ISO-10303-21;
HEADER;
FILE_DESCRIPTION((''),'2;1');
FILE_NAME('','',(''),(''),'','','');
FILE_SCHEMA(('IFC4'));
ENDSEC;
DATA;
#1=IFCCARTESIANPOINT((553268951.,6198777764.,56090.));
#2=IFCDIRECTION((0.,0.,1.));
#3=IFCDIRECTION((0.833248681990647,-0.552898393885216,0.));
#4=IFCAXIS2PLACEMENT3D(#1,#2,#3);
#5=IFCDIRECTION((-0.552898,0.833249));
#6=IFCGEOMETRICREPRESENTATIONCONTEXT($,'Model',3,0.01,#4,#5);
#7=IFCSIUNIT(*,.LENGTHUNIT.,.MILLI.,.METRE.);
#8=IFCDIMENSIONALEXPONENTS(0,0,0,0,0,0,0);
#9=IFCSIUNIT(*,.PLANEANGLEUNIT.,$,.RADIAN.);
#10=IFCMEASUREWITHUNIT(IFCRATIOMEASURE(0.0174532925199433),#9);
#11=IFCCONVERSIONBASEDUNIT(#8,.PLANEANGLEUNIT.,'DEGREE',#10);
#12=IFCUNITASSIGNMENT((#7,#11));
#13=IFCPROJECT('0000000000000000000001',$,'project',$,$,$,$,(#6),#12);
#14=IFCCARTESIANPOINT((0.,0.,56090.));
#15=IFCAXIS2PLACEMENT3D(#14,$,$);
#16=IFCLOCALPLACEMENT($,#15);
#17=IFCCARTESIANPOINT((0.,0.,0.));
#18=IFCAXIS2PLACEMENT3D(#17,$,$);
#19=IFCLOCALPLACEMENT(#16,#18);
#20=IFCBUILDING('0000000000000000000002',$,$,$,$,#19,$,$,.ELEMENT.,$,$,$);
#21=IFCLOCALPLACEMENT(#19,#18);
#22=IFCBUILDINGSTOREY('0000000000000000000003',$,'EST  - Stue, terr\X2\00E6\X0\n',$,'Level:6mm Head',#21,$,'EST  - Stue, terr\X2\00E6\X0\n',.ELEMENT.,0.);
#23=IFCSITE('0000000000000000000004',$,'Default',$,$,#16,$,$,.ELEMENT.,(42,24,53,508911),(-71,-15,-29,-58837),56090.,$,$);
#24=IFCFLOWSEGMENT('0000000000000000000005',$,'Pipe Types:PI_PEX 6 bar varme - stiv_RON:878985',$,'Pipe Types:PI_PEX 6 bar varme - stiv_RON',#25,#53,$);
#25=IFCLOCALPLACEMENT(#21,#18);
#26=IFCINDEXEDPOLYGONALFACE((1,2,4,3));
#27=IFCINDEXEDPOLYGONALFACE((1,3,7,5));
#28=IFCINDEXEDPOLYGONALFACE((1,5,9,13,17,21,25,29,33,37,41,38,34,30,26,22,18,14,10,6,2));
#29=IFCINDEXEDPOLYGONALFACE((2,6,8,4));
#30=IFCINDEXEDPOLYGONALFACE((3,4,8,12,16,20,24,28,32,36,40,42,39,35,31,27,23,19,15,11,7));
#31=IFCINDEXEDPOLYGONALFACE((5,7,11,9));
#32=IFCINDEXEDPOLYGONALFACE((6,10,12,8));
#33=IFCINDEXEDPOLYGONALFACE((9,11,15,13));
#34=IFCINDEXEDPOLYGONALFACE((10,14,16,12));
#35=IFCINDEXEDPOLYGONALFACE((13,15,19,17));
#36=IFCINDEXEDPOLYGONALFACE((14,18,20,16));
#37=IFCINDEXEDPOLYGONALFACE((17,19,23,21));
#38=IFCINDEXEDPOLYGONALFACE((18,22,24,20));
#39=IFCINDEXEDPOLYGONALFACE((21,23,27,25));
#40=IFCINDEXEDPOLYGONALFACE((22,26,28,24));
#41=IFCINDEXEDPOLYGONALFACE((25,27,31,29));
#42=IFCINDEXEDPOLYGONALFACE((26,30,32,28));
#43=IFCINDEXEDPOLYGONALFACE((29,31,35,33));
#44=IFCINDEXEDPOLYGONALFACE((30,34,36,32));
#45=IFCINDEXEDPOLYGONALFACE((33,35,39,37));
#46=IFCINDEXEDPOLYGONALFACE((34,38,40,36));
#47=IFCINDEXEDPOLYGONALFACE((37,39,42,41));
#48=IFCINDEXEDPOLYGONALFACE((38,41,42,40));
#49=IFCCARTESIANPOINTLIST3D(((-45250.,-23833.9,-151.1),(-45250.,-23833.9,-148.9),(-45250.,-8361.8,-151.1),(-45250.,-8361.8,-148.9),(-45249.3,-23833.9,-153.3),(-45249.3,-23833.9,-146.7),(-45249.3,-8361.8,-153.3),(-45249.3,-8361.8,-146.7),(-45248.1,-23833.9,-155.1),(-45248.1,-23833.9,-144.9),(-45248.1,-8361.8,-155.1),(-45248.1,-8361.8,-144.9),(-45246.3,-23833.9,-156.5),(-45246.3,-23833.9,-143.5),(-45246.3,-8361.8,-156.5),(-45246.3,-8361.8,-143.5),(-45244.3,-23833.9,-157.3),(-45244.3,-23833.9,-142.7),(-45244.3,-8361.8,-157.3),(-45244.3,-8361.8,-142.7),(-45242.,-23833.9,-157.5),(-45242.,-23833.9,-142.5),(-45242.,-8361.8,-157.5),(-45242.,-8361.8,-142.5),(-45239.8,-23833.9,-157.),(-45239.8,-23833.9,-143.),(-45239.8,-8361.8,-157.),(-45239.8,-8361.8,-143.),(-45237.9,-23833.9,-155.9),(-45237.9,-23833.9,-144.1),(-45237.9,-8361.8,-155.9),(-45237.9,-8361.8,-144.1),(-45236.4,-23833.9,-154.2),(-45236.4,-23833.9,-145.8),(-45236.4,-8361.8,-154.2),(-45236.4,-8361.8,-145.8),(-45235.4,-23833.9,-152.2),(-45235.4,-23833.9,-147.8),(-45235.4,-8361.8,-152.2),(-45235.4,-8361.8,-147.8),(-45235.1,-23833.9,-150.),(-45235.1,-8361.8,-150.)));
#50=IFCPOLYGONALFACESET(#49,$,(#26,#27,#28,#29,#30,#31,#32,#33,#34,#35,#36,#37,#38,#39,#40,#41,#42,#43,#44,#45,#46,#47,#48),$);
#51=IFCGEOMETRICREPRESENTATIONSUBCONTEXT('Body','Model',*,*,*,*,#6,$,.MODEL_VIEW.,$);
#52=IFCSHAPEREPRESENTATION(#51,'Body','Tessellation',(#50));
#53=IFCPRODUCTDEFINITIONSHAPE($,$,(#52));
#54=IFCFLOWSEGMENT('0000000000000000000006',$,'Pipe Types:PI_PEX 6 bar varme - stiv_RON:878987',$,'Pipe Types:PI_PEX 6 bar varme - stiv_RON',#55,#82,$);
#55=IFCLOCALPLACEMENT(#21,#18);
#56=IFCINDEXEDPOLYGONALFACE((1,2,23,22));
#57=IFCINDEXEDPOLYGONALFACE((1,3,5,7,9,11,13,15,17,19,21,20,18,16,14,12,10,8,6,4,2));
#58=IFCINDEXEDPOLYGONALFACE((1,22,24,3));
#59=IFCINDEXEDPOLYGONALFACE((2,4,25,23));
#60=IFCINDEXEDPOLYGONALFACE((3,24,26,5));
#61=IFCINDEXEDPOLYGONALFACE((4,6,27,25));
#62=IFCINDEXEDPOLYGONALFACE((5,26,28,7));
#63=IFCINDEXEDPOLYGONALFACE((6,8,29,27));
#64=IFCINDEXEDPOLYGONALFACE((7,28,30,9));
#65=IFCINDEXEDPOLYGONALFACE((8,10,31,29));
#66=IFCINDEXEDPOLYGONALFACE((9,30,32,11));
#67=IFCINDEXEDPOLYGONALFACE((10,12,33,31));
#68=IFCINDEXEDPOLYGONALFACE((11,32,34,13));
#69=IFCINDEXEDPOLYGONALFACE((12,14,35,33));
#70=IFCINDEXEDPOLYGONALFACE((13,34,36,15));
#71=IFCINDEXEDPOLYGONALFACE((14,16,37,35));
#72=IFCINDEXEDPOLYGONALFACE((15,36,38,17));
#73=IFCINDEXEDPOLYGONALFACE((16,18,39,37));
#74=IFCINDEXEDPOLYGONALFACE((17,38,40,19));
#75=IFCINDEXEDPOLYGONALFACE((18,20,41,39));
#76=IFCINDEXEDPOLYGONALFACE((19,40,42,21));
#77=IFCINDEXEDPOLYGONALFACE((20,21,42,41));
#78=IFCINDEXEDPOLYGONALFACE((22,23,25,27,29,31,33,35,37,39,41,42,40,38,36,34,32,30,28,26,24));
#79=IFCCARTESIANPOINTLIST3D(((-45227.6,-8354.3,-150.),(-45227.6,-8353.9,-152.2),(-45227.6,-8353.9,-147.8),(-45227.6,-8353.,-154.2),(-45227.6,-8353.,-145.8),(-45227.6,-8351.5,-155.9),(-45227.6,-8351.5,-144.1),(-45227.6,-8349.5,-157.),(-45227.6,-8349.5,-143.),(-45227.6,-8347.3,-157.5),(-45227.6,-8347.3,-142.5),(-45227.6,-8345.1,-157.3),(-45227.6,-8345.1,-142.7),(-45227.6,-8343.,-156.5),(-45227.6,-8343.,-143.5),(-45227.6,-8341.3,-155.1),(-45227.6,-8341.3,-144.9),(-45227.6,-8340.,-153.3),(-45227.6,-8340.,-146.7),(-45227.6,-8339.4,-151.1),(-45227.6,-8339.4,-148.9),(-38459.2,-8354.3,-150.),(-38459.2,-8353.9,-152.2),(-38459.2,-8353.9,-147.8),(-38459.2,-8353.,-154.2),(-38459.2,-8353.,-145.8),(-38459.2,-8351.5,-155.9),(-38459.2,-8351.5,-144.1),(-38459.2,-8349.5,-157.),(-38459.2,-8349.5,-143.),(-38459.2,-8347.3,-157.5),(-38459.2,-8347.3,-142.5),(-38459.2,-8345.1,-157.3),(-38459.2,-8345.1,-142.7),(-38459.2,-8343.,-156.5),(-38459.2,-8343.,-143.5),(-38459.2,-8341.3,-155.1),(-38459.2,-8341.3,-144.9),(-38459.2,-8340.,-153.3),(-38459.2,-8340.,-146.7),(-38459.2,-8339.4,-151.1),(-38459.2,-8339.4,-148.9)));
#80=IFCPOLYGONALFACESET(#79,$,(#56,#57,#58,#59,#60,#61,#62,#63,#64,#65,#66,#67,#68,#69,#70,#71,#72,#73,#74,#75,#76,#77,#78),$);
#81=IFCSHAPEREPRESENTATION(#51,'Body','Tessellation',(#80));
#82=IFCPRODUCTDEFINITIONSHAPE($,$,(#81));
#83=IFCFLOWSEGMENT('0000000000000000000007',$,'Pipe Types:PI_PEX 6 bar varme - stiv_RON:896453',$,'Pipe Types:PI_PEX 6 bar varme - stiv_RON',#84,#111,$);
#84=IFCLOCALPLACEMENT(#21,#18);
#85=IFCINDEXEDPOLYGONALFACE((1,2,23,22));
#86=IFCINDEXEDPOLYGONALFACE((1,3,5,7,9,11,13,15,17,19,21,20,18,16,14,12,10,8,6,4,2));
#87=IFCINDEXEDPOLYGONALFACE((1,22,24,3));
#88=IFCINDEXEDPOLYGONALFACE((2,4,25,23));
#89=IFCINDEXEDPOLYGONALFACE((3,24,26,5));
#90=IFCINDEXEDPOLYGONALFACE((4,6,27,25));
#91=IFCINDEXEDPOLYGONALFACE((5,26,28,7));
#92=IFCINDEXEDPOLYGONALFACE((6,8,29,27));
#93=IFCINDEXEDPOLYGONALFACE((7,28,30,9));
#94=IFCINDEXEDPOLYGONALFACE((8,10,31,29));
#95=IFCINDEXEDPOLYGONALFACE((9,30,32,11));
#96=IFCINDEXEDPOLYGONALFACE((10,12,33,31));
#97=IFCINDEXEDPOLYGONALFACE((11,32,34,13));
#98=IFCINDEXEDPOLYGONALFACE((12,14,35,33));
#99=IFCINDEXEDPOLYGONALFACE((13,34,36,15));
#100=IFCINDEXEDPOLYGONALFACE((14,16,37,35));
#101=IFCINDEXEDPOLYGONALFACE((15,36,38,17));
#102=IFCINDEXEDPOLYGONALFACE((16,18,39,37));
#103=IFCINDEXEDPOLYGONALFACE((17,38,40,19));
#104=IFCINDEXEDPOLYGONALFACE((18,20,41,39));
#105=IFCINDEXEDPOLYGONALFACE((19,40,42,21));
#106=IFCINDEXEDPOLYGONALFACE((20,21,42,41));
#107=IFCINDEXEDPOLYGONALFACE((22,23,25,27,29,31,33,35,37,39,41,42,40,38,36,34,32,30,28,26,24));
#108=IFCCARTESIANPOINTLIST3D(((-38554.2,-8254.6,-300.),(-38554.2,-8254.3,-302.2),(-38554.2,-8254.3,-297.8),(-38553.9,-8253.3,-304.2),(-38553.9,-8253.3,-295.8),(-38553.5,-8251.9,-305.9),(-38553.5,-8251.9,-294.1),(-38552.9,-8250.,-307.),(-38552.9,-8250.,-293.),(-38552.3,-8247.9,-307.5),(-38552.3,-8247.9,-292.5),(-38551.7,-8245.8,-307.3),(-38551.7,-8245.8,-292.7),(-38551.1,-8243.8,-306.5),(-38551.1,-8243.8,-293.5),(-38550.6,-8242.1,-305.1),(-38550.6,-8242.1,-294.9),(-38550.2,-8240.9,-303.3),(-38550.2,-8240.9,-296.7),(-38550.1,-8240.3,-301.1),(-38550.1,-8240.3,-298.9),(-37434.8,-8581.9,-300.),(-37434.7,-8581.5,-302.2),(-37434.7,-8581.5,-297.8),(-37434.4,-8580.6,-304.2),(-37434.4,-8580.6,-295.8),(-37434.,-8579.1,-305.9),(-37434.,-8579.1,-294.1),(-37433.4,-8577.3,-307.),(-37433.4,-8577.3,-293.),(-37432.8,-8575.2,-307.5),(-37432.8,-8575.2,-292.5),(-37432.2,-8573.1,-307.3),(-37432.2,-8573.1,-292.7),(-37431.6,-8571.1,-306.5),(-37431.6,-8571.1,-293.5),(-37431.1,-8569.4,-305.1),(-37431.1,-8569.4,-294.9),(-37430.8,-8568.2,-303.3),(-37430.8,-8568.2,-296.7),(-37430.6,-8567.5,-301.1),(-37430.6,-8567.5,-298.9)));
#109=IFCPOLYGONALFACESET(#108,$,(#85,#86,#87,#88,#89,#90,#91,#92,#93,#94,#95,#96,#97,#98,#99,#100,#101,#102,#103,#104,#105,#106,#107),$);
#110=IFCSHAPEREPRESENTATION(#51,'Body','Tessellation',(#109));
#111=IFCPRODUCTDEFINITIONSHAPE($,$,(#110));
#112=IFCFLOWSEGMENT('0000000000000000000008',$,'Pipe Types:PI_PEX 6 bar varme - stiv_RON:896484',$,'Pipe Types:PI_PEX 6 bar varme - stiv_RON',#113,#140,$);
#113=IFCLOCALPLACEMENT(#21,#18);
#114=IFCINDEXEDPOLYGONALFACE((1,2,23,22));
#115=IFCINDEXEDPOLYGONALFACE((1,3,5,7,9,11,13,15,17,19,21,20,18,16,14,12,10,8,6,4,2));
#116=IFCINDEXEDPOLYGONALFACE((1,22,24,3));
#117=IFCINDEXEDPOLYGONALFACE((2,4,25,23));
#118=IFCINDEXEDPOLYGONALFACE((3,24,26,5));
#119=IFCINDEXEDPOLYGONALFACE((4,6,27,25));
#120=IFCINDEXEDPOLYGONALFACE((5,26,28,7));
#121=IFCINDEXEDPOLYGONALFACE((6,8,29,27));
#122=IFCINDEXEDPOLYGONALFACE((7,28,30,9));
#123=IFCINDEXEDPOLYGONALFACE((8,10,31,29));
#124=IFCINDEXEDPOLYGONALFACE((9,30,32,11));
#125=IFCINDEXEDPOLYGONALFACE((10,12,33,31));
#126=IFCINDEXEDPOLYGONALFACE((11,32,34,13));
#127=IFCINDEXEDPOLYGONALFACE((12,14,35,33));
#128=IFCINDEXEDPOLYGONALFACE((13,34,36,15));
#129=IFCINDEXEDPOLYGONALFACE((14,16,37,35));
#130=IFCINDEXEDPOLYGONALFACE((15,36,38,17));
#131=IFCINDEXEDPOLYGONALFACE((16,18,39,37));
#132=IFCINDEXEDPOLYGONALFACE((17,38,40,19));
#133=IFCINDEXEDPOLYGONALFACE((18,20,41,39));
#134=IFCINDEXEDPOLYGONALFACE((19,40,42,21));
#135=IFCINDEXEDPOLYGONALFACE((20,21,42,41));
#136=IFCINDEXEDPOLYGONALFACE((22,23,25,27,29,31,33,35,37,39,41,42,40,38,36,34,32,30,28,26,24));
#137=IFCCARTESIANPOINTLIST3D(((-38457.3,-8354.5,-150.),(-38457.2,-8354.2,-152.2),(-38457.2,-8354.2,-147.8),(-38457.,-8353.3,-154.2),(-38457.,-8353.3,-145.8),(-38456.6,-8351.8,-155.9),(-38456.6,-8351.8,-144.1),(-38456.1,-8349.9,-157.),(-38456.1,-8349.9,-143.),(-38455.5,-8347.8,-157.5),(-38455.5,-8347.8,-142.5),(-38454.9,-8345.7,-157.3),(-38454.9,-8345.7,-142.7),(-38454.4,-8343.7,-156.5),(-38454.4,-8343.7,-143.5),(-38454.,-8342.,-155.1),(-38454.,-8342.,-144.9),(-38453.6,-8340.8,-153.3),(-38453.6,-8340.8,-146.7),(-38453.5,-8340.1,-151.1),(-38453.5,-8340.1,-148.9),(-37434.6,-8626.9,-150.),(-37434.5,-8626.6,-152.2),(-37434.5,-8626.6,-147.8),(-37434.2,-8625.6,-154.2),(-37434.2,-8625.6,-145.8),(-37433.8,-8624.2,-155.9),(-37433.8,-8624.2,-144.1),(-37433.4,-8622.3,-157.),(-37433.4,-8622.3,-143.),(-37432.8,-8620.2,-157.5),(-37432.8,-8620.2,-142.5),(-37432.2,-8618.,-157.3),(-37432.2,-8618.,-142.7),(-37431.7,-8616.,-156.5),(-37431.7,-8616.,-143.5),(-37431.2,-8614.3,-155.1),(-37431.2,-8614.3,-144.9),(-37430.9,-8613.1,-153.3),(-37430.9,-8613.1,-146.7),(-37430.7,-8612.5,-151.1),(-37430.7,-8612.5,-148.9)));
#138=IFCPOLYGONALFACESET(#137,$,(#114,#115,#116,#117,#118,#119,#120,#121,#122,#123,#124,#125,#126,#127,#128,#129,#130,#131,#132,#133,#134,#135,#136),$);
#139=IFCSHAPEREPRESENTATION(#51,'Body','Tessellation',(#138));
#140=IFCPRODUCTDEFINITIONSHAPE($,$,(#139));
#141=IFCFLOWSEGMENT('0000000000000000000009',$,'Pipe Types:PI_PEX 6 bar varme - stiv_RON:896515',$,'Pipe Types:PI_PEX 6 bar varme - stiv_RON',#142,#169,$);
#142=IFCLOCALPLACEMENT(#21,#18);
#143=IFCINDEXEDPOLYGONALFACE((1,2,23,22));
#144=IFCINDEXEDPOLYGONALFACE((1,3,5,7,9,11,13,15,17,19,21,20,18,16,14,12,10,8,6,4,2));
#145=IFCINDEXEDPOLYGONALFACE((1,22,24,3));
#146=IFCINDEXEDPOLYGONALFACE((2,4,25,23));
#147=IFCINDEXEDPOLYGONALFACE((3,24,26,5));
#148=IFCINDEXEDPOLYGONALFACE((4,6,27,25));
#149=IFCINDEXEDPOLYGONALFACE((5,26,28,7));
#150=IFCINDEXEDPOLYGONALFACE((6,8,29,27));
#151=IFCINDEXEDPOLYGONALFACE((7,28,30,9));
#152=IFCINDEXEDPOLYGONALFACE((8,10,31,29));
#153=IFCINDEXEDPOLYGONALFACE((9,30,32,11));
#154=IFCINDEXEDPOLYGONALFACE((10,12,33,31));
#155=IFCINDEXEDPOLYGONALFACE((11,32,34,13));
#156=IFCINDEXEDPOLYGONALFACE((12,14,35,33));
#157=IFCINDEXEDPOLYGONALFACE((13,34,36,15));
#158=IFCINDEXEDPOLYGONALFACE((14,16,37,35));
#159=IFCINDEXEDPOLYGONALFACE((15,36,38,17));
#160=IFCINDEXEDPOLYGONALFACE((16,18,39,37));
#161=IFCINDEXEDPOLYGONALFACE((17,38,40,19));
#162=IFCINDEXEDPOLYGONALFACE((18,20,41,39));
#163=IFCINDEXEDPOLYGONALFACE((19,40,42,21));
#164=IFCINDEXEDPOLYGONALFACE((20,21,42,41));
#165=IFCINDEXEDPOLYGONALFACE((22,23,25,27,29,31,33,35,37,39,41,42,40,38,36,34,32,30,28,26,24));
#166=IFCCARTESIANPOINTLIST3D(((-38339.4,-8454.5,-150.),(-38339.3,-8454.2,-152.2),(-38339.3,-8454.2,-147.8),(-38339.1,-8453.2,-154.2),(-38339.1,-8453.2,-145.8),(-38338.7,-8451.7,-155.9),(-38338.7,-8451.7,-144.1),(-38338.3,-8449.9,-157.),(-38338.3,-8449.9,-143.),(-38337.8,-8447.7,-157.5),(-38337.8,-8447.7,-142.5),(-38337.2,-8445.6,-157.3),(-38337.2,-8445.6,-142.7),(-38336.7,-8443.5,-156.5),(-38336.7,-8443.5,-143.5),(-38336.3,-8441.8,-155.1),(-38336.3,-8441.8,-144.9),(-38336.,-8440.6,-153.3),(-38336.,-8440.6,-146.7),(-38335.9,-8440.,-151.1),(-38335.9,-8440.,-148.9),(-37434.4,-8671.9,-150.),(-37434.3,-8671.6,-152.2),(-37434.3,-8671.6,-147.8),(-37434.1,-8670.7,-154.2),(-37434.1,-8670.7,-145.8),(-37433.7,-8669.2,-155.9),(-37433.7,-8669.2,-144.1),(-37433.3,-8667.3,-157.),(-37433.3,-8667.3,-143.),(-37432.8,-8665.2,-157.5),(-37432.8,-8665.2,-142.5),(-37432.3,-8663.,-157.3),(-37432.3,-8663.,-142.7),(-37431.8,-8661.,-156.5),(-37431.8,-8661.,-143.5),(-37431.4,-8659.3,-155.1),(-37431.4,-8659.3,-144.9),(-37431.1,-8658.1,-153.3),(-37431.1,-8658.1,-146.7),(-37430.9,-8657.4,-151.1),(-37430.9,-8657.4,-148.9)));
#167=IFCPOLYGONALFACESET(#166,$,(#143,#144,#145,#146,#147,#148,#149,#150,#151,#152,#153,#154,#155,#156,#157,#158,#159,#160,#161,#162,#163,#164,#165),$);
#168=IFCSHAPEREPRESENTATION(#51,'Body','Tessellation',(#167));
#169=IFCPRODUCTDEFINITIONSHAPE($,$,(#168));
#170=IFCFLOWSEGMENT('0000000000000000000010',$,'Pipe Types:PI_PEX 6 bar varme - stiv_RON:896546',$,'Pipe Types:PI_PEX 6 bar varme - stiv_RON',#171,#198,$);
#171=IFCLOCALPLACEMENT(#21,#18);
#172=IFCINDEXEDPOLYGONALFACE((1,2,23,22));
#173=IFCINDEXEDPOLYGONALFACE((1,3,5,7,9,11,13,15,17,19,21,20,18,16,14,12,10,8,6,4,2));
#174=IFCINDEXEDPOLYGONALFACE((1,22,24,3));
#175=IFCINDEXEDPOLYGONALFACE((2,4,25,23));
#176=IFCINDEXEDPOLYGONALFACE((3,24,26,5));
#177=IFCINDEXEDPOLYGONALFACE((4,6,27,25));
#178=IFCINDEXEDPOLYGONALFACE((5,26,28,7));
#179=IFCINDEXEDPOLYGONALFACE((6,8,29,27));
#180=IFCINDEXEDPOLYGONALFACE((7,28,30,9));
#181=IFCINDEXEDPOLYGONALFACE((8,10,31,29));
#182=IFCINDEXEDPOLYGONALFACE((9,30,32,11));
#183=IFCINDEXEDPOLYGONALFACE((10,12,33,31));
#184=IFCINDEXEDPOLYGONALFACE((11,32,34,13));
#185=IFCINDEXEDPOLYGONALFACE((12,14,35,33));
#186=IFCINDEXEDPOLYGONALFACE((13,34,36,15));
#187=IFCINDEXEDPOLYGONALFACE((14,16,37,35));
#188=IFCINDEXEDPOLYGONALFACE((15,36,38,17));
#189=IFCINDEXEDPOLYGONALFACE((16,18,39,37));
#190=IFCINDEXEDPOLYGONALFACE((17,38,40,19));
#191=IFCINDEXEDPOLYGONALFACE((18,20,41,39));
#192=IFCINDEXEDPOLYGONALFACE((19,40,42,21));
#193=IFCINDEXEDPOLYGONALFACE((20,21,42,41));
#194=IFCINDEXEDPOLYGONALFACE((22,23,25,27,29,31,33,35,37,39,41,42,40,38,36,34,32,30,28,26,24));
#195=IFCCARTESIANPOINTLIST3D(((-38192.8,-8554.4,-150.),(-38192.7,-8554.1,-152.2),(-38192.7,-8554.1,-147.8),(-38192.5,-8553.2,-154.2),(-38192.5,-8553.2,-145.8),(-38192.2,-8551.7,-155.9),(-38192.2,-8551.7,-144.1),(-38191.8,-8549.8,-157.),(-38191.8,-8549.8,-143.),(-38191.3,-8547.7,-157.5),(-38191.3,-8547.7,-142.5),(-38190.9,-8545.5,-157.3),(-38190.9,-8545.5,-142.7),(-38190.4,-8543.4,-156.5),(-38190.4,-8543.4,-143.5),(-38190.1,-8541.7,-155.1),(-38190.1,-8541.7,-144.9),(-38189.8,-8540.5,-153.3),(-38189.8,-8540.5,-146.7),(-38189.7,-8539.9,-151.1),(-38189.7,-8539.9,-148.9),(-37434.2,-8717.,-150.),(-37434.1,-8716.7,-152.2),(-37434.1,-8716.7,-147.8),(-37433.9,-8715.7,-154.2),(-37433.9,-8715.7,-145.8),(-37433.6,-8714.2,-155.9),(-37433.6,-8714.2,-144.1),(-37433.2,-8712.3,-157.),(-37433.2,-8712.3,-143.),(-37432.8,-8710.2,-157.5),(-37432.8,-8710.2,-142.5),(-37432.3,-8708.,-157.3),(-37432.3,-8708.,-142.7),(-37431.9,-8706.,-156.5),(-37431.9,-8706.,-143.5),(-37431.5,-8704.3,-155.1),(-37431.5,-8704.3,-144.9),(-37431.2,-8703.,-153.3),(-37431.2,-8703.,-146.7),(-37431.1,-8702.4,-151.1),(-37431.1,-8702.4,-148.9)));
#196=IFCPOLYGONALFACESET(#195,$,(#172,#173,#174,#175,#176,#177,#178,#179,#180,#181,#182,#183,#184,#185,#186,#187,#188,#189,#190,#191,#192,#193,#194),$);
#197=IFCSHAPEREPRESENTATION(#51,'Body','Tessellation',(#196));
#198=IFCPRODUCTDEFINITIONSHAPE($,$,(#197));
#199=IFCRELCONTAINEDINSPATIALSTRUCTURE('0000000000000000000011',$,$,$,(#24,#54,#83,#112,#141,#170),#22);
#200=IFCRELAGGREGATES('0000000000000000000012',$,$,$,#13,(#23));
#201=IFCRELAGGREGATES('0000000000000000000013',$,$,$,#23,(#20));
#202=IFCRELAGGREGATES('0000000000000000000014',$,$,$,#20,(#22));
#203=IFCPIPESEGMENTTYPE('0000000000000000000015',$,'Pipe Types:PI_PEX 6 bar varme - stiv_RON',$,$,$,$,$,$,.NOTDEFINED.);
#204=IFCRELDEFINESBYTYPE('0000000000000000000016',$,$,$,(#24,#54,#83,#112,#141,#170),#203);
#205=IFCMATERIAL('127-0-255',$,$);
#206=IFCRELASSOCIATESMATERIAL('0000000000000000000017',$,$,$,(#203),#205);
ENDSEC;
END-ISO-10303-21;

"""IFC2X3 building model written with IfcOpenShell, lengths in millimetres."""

from ifc_helpers import new_model, entity, si_unit, converted_unit, direction, frame, frame_2d, origin, origin_2d_with_axis, place, context, subcontext, project, spatial, circle, extrude, material, type_object, element, save


model = new_model("IFC2X3")

# Units and contexts
model_context = context("Model", 3, precision=0.01, world=frame((553268951.0, 6198777764.0, 56090.0), z_axis=(0.0, 0.0, 1.0), x_axis=(0.833248681990647, -0.552898393885216, 0.0)), true_north=direction((-0.552898, 0.833249)))
body_context = subcontext(model_context, "Body", "Model", "MODEL_VIEW")
ifc_project = project(units=[si_unit("LENGTHUNIT", "METRE", prefix="MILLI"), converted_unit("PLANEANGLEUNIT", "DEGREE", entity("IfcRatioMeasure", 0.0174532925199433), si_unit("PLANEANGLEUNIT", "RADIAN"), dimensions=[0, 0, 0, 0, 0, 0, 0])], contexts=[model_context])

# Site, building, storey
site_placement = place(None, frame((0.0, 0.0, 56090.0)))
site = spatial("IfcSite", under=ifc_project, at=site_placement, Name="Default", CompositionType="ELEMENT", RefLatitude=(42, 24, 53, 508911), RefLongitude=(-71, -15, -29, -58837), RefElevation=56090.0)
building_placement = place(site_placement, origin())
building = spatial("IfcBuilding", under=site, at=building_placement, CompositionType="ELEMENT")
storey_placement = place(building_placement, frame((0.0, 0.0, 0.0)))
storey = spatial("IfcBuildingStorey", under=building, at=storey_placement, Name="EST  - Stue, terræn", ObjectType="Level:6mm Head", LongName="EST  - Stue, terræn", CompositionType="ELEMENT", Elevation=0.0)

# Flow segments
ifc_material_1 = material(Name="127-0-255")
pipe_segment_type_1 = type_object("IfcPipeSegmentType", Name="Pipe Types:PI_PEX 6 bar varme - stiv_RON", PredefinedType="NOTDEFINED", material=ifc_material_1)
flow_segment_1_placement = place(storey_placement, origin())
element("IfcFlowSegment", 1, at=flow_segment_1_placement, inside=storey, type_object=pipe_segment_type_1, Name="Pipe Types:PI_PEX 6 bar varme - stiv_RON:878985", ObjectType="Pipe Types:PI_PEX 6 bar varme - stiv_RON", context=body_context, shape_type="SweptSolid", body=[
    extrude(circle(Radius=7.5, at=origin_2d_with_axis()), frame((-45242.6, -23833.9, -150.0), z_axis=(0.0, 1.0, 0.0), x_axis=(1.0, 0.0, 0.0)), (0.0, 0.0, 1.0), 15472.1),
])
flow_segment_2_placement = place(storey_placement, origin())
element("IfcFlowSegment", 2, at=flow_segment_2_placement, inside=storey, type_object=pipe_segment_type_1, Name="Pipe Types:PI_PEX 6 bar varme - stiv_RON:878987", ObjectType="Pipe Types:PI_PEX 6 bar varme - stiv_RON", context=body_context, shape_type="SweptSolid", body=[
    extrude(circle(Radius=7.5, at=origin_2d_with_axis()), frame((-45227.6, -8346.8, -150.0), z_axis=(1.0, 0.0, 0.0), x_axis=(0.0, -1.0, 0.0)), (0.0, 0.0, 1.0), 6768.4),
])
flow_segment_3_placement = place(storey_placement, origin())
element("IfcFlowSegment", 3, at=flow_segment_3_placement, inside=storey, type_object=pipe_segment_type_1, Name="Pipe Types:PI_PEX 6 bar varme - stiv_RON:896453", ObjectType="Pipe Types:PI_PEX 6 bar varme - stiv_RON", context=body_context, shape_type="SweptSolid", body=[
    extrude(circle(Radius=7.5, at=frame_2d((0.0, 0.0), x_axis=(1.0, 0.0))), frame((-37432.6, -8574.7, -300.0), z_axis=(-0.959827, 0.280593, 0.0), x_axis=(-0.280593, -0.959827, 0.0)), (0.0, 0.0, 1.0), 1166.4),
])
flow_segment_4_placement = place(storey_placement, origin())
element("IfcFlowSegment", 4, at=flow_segment_4_placement, inside=storey, type_object=pipe_segment_type_1, Name="Pipe Types:PI_PEX 6 bar varme - stiv_RON:896484", ObjectType="Pipe Types:PI_PEX 6 bar varme - stiv_RON", context=body_context, shape_type="SweptSolid", body=[
    extrude(circle(Radius=7.5, at=origin_2d_with_axis()), frame((-38455.4, -8347.3, -150.0), z_axis=(0.966319, -0.257345, 0.0), x_axis=(-0.257345, -0.966319, 0.0)), (0.0, 0.0, 1.0), 1058.4),
])
flow_segment_5_placement = place(storey_placement, origin())
element("IfcFlowSegment", 5, at=flow_segment_5_placement, inside=storey, type_object=pipe_segment_type_1, Name="Pipe Types:PI_PEX 6 bar varme - stiv_RON:896515", ObjectType="Pipe Types:PI_PEX 6 bar varme - stiv_RON", context=body_context, shape_type="SweptSolid", body=[
    extrude(circle(Radius=7.5, at=frame_2d((0.0, 0.0), x_axis=(1.0, 0.0))), frame((-37432.6, -8664.7, -150.0), z_axis=(-0.972323, 0.233642, 0.0), x_axis=(-0.233642, -0.972323, 0.0)), (0.0, 0.0, 1.0), 930.7),
])
flow_segment_6_placement = place(storey_placement, origin())
element("IfcFlowSegment", 6, at=flow_segment_6_placement, inside=storey, type_object=pipe_segment_type_1, Name="Pipe Types:PI_PEX 6 bar varme - stiv_RON:896546", ObjectType="Pipe Types:PI_PEX 6 bar varme - stiv_RON", context=body_context, shape_type="SweptSolid", body=[
    extrude(circle(Radius=7.5, at=frame_2d((0.0, 0.0), x_axis=(1.0, 0.0))), frame((-37432.6, -8709.7, -150.0), z_axis=(-0.977806, 0.209515, 0.0), x_axis=(-0.209515, -0.977806, 0.0)), (0.0, 0.0, 1.0), 775.8),
])

save(model, "model.ifc")
